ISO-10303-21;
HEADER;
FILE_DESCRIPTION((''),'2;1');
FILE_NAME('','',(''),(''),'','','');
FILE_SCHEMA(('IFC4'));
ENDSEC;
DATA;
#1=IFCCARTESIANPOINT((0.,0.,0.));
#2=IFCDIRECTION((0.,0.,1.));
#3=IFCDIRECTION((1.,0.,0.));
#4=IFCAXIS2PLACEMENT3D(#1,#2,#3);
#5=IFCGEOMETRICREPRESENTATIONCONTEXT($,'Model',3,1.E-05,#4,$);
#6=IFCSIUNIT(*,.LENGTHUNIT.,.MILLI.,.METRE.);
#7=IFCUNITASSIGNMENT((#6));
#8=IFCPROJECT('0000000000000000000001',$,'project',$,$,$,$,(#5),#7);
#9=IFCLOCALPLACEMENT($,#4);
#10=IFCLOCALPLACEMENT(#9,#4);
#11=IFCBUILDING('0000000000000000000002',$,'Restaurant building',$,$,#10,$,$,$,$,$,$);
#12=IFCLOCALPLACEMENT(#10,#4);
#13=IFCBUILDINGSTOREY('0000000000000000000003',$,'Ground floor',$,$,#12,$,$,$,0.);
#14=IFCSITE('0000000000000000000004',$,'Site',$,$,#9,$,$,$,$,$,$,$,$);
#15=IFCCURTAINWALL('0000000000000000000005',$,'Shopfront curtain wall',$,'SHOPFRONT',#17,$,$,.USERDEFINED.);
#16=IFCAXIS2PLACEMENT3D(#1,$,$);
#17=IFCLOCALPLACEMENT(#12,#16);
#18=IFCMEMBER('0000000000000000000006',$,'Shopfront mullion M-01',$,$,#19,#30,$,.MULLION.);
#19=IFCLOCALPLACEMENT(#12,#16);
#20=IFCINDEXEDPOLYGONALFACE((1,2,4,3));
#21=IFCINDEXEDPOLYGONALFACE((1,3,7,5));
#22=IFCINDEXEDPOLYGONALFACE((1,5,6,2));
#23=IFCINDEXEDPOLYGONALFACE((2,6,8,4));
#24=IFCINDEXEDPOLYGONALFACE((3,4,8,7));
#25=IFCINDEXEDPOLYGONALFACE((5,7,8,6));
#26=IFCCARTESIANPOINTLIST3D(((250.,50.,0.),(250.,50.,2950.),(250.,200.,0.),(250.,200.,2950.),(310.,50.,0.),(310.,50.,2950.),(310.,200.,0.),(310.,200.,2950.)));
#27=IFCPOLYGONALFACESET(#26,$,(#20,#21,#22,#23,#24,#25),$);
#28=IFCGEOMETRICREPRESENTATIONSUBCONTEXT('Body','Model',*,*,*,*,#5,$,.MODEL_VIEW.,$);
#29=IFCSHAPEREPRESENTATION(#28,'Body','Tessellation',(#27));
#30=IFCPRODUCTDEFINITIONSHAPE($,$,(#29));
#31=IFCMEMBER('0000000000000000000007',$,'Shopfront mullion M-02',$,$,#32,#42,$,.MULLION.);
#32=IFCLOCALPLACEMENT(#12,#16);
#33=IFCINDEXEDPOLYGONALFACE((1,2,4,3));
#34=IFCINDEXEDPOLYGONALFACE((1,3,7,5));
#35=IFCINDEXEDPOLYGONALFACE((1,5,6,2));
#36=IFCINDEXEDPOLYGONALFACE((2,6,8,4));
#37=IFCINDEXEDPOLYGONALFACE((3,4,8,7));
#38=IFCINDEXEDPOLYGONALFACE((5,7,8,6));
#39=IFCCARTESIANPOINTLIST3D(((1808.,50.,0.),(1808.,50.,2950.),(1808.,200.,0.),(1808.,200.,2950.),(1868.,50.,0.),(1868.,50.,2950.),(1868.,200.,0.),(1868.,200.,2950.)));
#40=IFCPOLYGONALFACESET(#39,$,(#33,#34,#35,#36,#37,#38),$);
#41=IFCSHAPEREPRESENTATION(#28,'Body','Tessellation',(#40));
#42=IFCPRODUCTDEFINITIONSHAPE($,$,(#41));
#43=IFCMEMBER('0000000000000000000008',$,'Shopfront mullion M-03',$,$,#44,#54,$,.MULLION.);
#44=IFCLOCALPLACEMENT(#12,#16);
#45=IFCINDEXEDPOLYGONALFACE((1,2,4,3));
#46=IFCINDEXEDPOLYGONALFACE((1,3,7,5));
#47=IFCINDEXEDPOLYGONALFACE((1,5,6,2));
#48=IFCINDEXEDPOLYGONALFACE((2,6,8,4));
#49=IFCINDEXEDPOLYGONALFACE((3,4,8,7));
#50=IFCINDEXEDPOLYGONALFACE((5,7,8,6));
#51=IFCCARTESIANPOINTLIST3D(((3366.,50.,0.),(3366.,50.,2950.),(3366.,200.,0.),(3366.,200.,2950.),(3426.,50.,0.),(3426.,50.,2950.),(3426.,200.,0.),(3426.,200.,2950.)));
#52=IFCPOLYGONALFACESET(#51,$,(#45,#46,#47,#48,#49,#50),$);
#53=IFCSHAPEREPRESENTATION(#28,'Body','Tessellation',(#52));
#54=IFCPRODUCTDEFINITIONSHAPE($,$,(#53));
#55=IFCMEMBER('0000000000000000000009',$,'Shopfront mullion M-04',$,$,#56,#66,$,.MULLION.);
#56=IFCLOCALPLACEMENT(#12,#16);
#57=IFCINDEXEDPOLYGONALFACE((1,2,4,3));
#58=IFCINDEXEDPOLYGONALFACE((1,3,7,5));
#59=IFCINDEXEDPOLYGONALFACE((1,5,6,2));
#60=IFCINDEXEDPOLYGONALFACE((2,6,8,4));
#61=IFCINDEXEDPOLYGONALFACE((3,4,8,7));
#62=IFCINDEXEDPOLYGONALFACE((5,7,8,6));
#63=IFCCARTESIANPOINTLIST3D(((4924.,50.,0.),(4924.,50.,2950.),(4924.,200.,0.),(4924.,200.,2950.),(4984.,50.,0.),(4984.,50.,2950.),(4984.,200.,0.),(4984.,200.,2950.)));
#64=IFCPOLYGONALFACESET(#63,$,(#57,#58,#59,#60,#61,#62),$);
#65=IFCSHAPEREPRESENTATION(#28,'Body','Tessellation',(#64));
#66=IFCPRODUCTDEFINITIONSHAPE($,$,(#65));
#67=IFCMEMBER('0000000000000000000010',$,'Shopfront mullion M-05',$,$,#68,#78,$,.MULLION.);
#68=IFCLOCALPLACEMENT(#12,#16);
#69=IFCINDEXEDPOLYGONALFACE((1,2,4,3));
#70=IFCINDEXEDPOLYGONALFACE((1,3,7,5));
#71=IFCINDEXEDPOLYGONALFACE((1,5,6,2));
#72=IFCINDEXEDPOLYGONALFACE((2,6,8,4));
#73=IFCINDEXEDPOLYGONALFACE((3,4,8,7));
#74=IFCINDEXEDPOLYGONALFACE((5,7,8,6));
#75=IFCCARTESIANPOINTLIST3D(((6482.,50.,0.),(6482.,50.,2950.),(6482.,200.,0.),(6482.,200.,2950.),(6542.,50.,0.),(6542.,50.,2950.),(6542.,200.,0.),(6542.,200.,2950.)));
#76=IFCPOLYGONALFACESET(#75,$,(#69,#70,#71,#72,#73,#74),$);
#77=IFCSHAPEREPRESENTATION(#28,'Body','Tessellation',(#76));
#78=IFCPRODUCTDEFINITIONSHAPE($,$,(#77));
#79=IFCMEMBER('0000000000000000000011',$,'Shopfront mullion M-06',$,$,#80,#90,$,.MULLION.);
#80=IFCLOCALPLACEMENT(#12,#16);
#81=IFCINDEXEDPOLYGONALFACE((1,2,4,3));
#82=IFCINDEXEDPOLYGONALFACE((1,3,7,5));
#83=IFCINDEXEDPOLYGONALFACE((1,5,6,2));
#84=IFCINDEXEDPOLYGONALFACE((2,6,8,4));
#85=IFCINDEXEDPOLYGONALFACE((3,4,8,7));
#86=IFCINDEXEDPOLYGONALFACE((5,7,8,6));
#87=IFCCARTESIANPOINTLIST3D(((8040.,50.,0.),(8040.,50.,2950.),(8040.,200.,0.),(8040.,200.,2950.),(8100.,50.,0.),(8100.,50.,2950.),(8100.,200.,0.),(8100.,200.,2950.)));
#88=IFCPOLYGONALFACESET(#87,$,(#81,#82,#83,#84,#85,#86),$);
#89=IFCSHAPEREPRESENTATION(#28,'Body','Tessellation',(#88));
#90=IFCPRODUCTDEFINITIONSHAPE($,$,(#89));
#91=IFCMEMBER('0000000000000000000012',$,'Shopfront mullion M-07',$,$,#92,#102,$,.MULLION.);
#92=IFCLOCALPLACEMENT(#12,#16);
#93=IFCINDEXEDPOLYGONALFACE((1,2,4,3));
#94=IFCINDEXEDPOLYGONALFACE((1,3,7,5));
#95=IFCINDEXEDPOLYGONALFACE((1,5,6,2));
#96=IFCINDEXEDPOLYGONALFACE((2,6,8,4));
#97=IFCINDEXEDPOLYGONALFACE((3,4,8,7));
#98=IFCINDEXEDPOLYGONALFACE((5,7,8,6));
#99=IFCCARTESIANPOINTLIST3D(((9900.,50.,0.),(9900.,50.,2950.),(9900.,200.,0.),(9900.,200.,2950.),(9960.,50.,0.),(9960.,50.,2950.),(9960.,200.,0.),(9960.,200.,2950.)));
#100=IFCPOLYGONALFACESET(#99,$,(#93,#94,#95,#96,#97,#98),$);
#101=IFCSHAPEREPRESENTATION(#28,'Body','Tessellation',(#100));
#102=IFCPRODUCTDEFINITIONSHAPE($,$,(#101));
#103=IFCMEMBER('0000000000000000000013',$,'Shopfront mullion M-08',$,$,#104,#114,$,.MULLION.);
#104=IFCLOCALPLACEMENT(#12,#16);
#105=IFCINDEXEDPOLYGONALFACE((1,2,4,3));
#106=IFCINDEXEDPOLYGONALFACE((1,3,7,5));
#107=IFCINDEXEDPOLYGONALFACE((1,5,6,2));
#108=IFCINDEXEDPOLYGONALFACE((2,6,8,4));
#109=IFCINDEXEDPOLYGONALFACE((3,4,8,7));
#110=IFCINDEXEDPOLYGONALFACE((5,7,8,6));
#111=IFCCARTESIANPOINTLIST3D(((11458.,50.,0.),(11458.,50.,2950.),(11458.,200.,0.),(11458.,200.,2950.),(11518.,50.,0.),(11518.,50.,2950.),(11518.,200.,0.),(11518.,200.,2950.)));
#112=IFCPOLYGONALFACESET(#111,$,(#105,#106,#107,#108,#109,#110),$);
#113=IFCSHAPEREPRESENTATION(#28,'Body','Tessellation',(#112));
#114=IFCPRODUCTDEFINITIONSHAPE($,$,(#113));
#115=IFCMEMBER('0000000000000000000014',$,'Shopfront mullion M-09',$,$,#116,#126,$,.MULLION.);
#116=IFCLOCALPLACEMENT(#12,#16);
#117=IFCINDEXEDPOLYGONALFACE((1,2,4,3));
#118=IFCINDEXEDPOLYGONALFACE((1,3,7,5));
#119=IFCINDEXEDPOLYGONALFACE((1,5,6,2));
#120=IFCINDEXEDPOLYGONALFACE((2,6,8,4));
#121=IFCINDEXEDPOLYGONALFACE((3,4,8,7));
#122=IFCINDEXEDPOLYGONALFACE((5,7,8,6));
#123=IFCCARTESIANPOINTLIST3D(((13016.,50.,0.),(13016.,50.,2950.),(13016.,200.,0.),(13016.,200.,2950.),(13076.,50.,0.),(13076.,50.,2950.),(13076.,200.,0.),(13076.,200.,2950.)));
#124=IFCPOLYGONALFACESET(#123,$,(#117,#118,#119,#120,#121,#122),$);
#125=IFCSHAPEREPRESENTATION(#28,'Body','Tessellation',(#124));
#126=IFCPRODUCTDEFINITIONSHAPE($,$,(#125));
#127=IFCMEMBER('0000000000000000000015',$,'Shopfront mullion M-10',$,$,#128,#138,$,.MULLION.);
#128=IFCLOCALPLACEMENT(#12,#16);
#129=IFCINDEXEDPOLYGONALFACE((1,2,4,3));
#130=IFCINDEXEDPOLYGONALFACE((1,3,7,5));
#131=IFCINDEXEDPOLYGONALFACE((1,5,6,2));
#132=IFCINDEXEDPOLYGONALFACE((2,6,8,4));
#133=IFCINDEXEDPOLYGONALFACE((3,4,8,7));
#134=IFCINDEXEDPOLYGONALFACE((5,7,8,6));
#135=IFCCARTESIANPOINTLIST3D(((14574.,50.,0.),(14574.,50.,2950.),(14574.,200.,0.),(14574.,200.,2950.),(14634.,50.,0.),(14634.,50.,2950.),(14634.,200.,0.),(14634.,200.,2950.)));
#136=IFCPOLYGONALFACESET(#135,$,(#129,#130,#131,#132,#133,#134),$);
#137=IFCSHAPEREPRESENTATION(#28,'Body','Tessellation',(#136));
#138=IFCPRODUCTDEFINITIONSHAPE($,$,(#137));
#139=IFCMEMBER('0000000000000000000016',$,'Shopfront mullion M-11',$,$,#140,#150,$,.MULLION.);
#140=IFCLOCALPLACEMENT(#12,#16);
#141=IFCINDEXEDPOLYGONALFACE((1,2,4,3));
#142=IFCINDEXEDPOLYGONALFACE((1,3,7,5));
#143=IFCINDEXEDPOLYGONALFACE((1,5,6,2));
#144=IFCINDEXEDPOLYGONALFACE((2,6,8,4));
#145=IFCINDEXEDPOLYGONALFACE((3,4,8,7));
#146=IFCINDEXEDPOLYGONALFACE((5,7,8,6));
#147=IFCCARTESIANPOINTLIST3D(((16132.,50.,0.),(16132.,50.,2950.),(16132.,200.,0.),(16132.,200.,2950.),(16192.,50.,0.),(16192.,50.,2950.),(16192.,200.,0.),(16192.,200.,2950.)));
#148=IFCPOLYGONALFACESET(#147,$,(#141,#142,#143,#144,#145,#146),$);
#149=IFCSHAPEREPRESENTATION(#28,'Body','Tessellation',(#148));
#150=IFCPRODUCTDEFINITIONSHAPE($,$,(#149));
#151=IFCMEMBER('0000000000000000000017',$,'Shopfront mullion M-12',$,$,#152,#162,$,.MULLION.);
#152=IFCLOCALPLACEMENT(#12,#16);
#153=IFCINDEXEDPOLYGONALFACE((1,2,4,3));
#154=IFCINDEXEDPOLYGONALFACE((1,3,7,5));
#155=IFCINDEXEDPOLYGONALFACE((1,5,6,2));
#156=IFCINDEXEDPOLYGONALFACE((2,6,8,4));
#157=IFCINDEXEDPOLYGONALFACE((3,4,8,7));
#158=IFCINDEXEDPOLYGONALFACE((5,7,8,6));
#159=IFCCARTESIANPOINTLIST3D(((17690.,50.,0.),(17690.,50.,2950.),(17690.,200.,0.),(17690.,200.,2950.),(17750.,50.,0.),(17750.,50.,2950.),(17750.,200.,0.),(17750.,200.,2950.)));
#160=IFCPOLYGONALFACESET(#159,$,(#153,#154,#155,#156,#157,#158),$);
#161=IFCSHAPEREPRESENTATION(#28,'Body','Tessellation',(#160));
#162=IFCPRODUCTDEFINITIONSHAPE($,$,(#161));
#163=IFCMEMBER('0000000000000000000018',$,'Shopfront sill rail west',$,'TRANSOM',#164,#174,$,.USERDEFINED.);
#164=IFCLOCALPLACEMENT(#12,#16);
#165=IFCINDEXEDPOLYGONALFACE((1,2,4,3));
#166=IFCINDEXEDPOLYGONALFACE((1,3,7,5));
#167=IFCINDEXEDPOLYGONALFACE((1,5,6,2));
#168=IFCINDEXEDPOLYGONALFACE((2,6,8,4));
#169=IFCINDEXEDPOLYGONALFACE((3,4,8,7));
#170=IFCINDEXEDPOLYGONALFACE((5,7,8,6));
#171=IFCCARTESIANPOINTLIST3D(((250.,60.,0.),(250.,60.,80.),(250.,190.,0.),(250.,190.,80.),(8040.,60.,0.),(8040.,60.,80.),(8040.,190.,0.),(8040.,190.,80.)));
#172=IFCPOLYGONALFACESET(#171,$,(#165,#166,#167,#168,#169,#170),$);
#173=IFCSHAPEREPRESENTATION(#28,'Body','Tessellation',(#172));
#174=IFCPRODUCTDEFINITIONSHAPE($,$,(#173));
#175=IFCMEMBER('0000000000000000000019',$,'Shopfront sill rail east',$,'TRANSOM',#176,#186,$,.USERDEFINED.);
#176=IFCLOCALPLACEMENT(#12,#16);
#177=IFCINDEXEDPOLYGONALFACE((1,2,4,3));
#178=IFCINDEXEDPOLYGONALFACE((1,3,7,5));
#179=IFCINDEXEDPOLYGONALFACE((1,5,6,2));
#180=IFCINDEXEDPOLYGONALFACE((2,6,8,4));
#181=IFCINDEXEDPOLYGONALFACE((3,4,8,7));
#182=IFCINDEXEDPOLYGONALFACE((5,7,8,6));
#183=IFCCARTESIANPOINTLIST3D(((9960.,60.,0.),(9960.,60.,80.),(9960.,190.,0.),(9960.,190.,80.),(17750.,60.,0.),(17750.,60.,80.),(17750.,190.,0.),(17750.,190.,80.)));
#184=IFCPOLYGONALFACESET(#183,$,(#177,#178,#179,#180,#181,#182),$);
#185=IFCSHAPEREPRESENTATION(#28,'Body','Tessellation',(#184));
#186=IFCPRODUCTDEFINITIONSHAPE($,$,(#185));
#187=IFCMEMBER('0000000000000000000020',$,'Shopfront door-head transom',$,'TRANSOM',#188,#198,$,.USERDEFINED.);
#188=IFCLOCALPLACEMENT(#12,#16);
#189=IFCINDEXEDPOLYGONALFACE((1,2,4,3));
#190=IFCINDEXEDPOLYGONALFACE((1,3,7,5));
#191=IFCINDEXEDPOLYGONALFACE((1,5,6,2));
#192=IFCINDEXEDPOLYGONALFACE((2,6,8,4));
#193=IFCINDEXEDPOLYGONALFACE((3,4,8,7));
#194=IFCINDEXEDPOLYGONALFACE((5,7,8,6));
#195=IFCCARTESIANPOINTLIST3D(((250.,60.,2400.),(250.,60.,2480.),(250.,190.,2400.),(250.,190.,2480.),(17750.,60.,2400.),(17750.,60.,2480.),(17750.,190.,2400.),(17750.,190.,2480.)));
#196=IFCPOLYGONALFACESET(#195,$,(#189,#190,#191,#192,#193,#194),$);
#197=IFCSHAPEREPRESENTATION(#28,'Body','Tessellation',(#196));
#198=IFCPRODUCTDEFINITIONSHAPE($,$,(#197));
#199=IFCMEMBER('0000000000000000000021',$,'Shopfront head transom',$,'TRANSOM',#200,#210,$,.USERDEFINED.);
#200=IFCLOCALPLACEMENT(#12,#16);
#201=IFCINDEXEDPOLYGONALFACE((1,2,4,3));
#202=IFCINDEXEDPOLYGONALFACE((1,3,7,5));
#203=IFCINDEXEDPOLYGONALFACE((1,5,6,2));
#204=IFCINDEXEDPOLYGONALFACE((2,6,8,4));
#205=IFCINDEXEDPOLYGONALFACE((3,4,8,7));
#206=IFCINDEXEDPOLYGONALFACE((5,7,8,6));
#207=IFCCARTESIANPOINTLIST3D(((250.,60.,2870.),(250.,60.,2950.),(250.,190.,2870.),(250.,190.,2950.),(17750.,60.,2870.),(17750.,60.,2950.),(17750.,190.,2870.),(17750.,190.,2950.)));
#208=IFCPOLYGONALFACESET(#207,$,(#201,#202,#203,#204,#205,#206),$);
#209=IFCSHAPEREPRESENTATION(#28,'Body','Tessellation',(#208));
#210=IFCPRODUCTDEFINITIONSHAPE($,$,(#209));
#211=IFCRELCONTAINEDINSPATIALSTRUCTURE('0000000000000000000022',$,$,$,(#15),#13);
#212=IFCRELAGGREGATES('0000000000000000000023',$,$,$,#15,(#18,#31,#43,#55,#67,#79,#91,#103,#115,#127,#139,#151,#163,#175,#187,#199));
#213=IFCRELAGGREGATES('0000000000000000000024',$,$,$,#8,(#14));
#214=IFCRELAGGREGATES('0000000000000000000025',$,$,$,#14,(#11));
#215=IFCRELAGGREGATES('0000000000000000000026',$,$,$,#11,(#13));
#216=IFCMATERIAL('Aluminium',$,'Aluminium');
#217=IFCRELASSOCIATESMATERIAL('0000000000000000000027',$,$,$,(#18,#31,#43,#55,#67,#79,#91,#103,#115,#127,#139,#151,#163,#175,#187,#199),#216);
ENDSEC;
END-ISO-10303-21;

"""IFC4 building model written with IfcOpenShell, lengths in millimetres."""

from ifc_helpers import new_model, si_unit, frame, origin, origin_with_axes, origin_2d, place, context, subcontext, project, spatial, rectangle, extrude, material, element, aggregate, save


model = new_model("IFC4")

# Units and contexts
model_context = context("Model", 3, precision=1e-05, world=origin_with_axes())
body_context = subcontext(model_context, "Body", "Model", "MODEL_VIEW")
ifc_project = project(units=[si_unit("LENGTHUNIT", "METRE", prefix="MILLI")], contexts=[model_context])

# Site, building, storey
site_placement = place(None, origin_with_axes())
site = spatial("IfcSite", under=ifc_project, at=site_placement, Name="Site")
building_placement = place(site_placement, origin_with_axes())
building = spatial("IfcBuilding", under=site, at=building_placement, Name="Restaurant building")
storey_placement = place(building_placement, origin_with_axes())
storey = spatial("IfcBuildingStorey", under=building, at=storey_placement, Name="Ground floor", Elevation=0.0)

# Curtain wall, members
curtain_wall_placement = place(storey_placement, origin())
curtain_wall = element("IfcCurtainWall", 1, at=curtain_wall_placement, inside=storey, Name="Shopfront curtain wall", ObjectType="SHOPFRONT", PredefinedType="USERDEFINED")
ifc_material_1 = material(Name="Aluminium", Category="Aluminium")
member_1_placement = place(curtain_wall_placement, origin_with_axes())
member_1 = element("IfcMember", 2, at=member_1_placement, material=ifc_material_1, Name="Shopfront mullion M-01", PredefinedType="MULLION", context=body_context, shape_type="SweptSolid", body=[
    extrude(rectangle(XDim=60.0, YDim=150.0, at=origin_2d()), frame((280.0, 125.0, 0.0)), (0.0, 0.0, 1.0), 2950.0),
])
member_2_placement = place(curtain_wall_placement, origin_with_axes())
member_2 = element("IfcMember", 3, at=member_2_placement, material=ifc_material_1, Name="Shopfront mullion M-02", PredefinedType="MULLION", context=body_context, shape_type="SweptSolid", body=[
    extrude(rectangle(XDim=60.0, YDim=150.0, at=origin_2d()), frame((1838.0, 125.0, 0.0)), (0.0, 0.0, 1.0), 2950.0),
])
member_3_placement = place(curtain_wall_placement, origin_with_axes())
member_3 = element("IfcMember", 4, at=member_3_placement, material=ifc_material_1, Name="Shopfront mullion M-03", PredefinedType="MULLION", context=body_context, shape_type="SweptSolid", body=[
    extrude(rectangle(XDim=60.0, YDim=150.0, at=origin_2d()), frame((3396.0, 125.0, 0.0)), (0.0, 0.0, 1.0), 2950.0),
])
member_4_placement = place(curtain_wall_placement, origin_with_axes())
member_4 = element("IfcMember", 5, at=member_4_placement, material=ifc_material_1, Name="Shopfront mullion M-04", PredefinedType="MULLION", context=body_context, shape_type="SweptSolid", body=[
    extrude(rectangle(XDim=60.0, YDim=150.0, at=origin_2d()), frame((4954.0, 125.0, 0.0)), (0.0, 0.0, 1.0), 2950.0),
])
member_5_placement = place(curtain_wall_placement, origin_with_axes())
member_5 = element("IfcMember", 6, at=member_5_placement, material=ifc_material_1, Name="Shopfront mullion M-05", PredefinedType="MULLION", context=body_context, shape_type="SweptSolid", body=[
    extrude(rectangle(XDim=60.0, YDim=150.0, at=origin_2d()), frame((6512.0, 125.0, 0.0)), (0.0, 0.0, 1.0), 2950.0),
])
member_6_placement = place(curtain_wall_placement, origin_with_axes())
member_6 = element("IfcMember", 7, at=member_6_placement, material=ifc_material_1, Name="Shopfront mullion M-06", PredefinedType="MULLION", context=body_context, shape_type="SweptSolid", body=[
    extrude(rectangle(XDim=60.0, YDim=150.0, at=origin_2d()), frame((8070.0, 125.0, 0.0)), (0.0, 0.0, 1.0), 2950.0),
])
member_7_placement = place(curtain_wall_placement, origin_with_axes())
member_7 = element("IfcMember", 8, at=member_7_placement, material=ifc_material_1, Name="Shopfront mullion M-07", PredefinedType="MULLION", context=body_context, shape_type="SweptSolid", body=[
    extrude(rectangle(XDim=60.0, YDim=150.0, at=origin_2d()), frame((9930.0, 125.0, 0.0)), (0.0, 0.0, 1.0), 2950.0),
])
member_8_placement = place(curtain_wall_placement, origin_with_axes())
member_8 = element("IfcMember", 9, at=member_8_placement, material=ifc_material_1, Name="Shopfront mullion M-08", PredefinedType="MULLION", context=body_context, shape_type="SweptSolid", body=[
    extrude(rectangle(XDim=60.0, YDim=150.0, at=origin_2d()), frame((11488.0, 125.0, 0.0)), (0.0, 0.0, 1.0), 2950.0),
])
member_9_placement = place(curtain_wall_placement, origin_with_axes())
member_9 = element("IfcMember", 10, at=member_9_placement, material=ifc_material_1, Name="Shopfront mullion M-09", PredefinedType="MULLION", context=body_context, shape_type="SweptSolid", body=[
    extrude(rectangle(XDim=60.0, YDim=150.0, at=origin_2d()), frame((13046.0, 125.0, 0.0)), (0.0, 0.0, 1.0), 2950.0),
])
member_10_placement = place(curtain_wall_placement, origin_with_axes())
member_10 = element("IfcMember", 11, at=member_10_placement, material=ifc_material_1, Name="Shopfront mullion M-10", PredefinedType="MULLION", context=body_context, shape_type="SweptSolid", body=[
    extrude(rectangle(XDim=60.0, YDim=150.0, at=origin_2d()), frame((14604.0, 125.0, 0.0)), (0.0, 0.0, 1.0), 2950.0),
])
member_11_placement = place(curtain_wall_placement, origin_with_axes())
member_11 = element("IfcMember", 12, at=member_11_placement, material=ifc_material_1, Name="Shopfront mullion M-11", PredefinedType="MULLION", context=body_context, shape_type="SweptSolid", body=[
    extrude(rectangle(XDim=60.0, YDim=150.0, at=origin_2d()), frame((16162.0, 125.0, 0.0)), (0.0, 0.0, 1.0), 2950.0),
])
member_12_placement = place(curtain_wall_placement, origin_with_axes())
member_12 = element("IfcMember", 13, at=member_12_placement, material=ifc_material_1, Name="Shopfront mullion M-12", PredefinedType="MULLION", context=body_context, shape_type="SweptSolid", body=[
    extrude(rectangle(XDim=60.0, YDim=150.0, at=origin_2d()), frame((17720.0, 125.0, 0.0)), (0.0, 0.0, 1.0), 2950.0),
])
member_13_placement = place(curtain_wall_placement, origin_with_axes())
member_13 = element("IfcMember", 14, at=member_13_placement, material=ifc_material_1, Name="Shopfront sill rail west", ObjectType="TRANSOM", PredefinedType="USERDEFINED", context=body_context, shape_type="SweptSolid", body=[
    extrude(rectangle(XDim=7790.0, YDim=130.0, at=origin_2d()), frame((4145.0, 125.0, 0.0)), (0.0, 0.0, 1.0), 80.0),
])
member_14_placement = place(curtain_wall_placement, origin_with_axes())
member_14 = element("IfcMember", 15, at=member_14_placement, material=ifc_material_1, Name="Shopfront sill rail east", ObjectType="TRANSOM", PredefinedType="USERDEFINED", context=body_context, shape_type="SweptSolid", body=[
    extrude(rectangle(XDim=7790.0, YDim=130.0, at=origin_2d()), frame((13855.0, 125.0, 0.0)), (0.0, 0.0, 1.0), 80.0),
])
member_15_placement = place(curtain_wall_placement, origin_with_axes())
member_15 = element("IfcMember", 16, at=member_15_placement, material=ifc_material_1, Name="Shopfront door-head transom", ObjectType="TRANSOM", PredefinedType="USERDEFINED", context=body_context, shape_type="SweptSolid", body=[
    extrude(rectangle(XDim=17500.0, YDim=130.0, at=origin_2d()), frame((9000.0, 125.0, 2400.0)), (0.0, 0.0, 1.0), 80.0),
])
member_16_placement = place(curtain_wall_placement, origin_with_axes())
member_16 = element("IfcMember", 17, at=member_16_placement, material=ifc_material_1, Name="Shopfront head transom", ObjectType="TRANSOM", PredefinedType="USERDEFINED", context=body_context, shape_type="SweptSolid", body=[
    extrude(rectangle(XDim=17500.0, YDim=130.0, at=origin_2d()), frame((9000.0, 125.0, 2870.0)), (0.0, 0.0, 1.0), 80.0),
])
aggregate(curtain_wall, [member_1, member_2, member_3, member_4, member_5, member_6, member_7, member_8, member_9, member_10, member_11, member_12, member_13, member_14, member_15, member_16])

save(model, "model.ifc")
